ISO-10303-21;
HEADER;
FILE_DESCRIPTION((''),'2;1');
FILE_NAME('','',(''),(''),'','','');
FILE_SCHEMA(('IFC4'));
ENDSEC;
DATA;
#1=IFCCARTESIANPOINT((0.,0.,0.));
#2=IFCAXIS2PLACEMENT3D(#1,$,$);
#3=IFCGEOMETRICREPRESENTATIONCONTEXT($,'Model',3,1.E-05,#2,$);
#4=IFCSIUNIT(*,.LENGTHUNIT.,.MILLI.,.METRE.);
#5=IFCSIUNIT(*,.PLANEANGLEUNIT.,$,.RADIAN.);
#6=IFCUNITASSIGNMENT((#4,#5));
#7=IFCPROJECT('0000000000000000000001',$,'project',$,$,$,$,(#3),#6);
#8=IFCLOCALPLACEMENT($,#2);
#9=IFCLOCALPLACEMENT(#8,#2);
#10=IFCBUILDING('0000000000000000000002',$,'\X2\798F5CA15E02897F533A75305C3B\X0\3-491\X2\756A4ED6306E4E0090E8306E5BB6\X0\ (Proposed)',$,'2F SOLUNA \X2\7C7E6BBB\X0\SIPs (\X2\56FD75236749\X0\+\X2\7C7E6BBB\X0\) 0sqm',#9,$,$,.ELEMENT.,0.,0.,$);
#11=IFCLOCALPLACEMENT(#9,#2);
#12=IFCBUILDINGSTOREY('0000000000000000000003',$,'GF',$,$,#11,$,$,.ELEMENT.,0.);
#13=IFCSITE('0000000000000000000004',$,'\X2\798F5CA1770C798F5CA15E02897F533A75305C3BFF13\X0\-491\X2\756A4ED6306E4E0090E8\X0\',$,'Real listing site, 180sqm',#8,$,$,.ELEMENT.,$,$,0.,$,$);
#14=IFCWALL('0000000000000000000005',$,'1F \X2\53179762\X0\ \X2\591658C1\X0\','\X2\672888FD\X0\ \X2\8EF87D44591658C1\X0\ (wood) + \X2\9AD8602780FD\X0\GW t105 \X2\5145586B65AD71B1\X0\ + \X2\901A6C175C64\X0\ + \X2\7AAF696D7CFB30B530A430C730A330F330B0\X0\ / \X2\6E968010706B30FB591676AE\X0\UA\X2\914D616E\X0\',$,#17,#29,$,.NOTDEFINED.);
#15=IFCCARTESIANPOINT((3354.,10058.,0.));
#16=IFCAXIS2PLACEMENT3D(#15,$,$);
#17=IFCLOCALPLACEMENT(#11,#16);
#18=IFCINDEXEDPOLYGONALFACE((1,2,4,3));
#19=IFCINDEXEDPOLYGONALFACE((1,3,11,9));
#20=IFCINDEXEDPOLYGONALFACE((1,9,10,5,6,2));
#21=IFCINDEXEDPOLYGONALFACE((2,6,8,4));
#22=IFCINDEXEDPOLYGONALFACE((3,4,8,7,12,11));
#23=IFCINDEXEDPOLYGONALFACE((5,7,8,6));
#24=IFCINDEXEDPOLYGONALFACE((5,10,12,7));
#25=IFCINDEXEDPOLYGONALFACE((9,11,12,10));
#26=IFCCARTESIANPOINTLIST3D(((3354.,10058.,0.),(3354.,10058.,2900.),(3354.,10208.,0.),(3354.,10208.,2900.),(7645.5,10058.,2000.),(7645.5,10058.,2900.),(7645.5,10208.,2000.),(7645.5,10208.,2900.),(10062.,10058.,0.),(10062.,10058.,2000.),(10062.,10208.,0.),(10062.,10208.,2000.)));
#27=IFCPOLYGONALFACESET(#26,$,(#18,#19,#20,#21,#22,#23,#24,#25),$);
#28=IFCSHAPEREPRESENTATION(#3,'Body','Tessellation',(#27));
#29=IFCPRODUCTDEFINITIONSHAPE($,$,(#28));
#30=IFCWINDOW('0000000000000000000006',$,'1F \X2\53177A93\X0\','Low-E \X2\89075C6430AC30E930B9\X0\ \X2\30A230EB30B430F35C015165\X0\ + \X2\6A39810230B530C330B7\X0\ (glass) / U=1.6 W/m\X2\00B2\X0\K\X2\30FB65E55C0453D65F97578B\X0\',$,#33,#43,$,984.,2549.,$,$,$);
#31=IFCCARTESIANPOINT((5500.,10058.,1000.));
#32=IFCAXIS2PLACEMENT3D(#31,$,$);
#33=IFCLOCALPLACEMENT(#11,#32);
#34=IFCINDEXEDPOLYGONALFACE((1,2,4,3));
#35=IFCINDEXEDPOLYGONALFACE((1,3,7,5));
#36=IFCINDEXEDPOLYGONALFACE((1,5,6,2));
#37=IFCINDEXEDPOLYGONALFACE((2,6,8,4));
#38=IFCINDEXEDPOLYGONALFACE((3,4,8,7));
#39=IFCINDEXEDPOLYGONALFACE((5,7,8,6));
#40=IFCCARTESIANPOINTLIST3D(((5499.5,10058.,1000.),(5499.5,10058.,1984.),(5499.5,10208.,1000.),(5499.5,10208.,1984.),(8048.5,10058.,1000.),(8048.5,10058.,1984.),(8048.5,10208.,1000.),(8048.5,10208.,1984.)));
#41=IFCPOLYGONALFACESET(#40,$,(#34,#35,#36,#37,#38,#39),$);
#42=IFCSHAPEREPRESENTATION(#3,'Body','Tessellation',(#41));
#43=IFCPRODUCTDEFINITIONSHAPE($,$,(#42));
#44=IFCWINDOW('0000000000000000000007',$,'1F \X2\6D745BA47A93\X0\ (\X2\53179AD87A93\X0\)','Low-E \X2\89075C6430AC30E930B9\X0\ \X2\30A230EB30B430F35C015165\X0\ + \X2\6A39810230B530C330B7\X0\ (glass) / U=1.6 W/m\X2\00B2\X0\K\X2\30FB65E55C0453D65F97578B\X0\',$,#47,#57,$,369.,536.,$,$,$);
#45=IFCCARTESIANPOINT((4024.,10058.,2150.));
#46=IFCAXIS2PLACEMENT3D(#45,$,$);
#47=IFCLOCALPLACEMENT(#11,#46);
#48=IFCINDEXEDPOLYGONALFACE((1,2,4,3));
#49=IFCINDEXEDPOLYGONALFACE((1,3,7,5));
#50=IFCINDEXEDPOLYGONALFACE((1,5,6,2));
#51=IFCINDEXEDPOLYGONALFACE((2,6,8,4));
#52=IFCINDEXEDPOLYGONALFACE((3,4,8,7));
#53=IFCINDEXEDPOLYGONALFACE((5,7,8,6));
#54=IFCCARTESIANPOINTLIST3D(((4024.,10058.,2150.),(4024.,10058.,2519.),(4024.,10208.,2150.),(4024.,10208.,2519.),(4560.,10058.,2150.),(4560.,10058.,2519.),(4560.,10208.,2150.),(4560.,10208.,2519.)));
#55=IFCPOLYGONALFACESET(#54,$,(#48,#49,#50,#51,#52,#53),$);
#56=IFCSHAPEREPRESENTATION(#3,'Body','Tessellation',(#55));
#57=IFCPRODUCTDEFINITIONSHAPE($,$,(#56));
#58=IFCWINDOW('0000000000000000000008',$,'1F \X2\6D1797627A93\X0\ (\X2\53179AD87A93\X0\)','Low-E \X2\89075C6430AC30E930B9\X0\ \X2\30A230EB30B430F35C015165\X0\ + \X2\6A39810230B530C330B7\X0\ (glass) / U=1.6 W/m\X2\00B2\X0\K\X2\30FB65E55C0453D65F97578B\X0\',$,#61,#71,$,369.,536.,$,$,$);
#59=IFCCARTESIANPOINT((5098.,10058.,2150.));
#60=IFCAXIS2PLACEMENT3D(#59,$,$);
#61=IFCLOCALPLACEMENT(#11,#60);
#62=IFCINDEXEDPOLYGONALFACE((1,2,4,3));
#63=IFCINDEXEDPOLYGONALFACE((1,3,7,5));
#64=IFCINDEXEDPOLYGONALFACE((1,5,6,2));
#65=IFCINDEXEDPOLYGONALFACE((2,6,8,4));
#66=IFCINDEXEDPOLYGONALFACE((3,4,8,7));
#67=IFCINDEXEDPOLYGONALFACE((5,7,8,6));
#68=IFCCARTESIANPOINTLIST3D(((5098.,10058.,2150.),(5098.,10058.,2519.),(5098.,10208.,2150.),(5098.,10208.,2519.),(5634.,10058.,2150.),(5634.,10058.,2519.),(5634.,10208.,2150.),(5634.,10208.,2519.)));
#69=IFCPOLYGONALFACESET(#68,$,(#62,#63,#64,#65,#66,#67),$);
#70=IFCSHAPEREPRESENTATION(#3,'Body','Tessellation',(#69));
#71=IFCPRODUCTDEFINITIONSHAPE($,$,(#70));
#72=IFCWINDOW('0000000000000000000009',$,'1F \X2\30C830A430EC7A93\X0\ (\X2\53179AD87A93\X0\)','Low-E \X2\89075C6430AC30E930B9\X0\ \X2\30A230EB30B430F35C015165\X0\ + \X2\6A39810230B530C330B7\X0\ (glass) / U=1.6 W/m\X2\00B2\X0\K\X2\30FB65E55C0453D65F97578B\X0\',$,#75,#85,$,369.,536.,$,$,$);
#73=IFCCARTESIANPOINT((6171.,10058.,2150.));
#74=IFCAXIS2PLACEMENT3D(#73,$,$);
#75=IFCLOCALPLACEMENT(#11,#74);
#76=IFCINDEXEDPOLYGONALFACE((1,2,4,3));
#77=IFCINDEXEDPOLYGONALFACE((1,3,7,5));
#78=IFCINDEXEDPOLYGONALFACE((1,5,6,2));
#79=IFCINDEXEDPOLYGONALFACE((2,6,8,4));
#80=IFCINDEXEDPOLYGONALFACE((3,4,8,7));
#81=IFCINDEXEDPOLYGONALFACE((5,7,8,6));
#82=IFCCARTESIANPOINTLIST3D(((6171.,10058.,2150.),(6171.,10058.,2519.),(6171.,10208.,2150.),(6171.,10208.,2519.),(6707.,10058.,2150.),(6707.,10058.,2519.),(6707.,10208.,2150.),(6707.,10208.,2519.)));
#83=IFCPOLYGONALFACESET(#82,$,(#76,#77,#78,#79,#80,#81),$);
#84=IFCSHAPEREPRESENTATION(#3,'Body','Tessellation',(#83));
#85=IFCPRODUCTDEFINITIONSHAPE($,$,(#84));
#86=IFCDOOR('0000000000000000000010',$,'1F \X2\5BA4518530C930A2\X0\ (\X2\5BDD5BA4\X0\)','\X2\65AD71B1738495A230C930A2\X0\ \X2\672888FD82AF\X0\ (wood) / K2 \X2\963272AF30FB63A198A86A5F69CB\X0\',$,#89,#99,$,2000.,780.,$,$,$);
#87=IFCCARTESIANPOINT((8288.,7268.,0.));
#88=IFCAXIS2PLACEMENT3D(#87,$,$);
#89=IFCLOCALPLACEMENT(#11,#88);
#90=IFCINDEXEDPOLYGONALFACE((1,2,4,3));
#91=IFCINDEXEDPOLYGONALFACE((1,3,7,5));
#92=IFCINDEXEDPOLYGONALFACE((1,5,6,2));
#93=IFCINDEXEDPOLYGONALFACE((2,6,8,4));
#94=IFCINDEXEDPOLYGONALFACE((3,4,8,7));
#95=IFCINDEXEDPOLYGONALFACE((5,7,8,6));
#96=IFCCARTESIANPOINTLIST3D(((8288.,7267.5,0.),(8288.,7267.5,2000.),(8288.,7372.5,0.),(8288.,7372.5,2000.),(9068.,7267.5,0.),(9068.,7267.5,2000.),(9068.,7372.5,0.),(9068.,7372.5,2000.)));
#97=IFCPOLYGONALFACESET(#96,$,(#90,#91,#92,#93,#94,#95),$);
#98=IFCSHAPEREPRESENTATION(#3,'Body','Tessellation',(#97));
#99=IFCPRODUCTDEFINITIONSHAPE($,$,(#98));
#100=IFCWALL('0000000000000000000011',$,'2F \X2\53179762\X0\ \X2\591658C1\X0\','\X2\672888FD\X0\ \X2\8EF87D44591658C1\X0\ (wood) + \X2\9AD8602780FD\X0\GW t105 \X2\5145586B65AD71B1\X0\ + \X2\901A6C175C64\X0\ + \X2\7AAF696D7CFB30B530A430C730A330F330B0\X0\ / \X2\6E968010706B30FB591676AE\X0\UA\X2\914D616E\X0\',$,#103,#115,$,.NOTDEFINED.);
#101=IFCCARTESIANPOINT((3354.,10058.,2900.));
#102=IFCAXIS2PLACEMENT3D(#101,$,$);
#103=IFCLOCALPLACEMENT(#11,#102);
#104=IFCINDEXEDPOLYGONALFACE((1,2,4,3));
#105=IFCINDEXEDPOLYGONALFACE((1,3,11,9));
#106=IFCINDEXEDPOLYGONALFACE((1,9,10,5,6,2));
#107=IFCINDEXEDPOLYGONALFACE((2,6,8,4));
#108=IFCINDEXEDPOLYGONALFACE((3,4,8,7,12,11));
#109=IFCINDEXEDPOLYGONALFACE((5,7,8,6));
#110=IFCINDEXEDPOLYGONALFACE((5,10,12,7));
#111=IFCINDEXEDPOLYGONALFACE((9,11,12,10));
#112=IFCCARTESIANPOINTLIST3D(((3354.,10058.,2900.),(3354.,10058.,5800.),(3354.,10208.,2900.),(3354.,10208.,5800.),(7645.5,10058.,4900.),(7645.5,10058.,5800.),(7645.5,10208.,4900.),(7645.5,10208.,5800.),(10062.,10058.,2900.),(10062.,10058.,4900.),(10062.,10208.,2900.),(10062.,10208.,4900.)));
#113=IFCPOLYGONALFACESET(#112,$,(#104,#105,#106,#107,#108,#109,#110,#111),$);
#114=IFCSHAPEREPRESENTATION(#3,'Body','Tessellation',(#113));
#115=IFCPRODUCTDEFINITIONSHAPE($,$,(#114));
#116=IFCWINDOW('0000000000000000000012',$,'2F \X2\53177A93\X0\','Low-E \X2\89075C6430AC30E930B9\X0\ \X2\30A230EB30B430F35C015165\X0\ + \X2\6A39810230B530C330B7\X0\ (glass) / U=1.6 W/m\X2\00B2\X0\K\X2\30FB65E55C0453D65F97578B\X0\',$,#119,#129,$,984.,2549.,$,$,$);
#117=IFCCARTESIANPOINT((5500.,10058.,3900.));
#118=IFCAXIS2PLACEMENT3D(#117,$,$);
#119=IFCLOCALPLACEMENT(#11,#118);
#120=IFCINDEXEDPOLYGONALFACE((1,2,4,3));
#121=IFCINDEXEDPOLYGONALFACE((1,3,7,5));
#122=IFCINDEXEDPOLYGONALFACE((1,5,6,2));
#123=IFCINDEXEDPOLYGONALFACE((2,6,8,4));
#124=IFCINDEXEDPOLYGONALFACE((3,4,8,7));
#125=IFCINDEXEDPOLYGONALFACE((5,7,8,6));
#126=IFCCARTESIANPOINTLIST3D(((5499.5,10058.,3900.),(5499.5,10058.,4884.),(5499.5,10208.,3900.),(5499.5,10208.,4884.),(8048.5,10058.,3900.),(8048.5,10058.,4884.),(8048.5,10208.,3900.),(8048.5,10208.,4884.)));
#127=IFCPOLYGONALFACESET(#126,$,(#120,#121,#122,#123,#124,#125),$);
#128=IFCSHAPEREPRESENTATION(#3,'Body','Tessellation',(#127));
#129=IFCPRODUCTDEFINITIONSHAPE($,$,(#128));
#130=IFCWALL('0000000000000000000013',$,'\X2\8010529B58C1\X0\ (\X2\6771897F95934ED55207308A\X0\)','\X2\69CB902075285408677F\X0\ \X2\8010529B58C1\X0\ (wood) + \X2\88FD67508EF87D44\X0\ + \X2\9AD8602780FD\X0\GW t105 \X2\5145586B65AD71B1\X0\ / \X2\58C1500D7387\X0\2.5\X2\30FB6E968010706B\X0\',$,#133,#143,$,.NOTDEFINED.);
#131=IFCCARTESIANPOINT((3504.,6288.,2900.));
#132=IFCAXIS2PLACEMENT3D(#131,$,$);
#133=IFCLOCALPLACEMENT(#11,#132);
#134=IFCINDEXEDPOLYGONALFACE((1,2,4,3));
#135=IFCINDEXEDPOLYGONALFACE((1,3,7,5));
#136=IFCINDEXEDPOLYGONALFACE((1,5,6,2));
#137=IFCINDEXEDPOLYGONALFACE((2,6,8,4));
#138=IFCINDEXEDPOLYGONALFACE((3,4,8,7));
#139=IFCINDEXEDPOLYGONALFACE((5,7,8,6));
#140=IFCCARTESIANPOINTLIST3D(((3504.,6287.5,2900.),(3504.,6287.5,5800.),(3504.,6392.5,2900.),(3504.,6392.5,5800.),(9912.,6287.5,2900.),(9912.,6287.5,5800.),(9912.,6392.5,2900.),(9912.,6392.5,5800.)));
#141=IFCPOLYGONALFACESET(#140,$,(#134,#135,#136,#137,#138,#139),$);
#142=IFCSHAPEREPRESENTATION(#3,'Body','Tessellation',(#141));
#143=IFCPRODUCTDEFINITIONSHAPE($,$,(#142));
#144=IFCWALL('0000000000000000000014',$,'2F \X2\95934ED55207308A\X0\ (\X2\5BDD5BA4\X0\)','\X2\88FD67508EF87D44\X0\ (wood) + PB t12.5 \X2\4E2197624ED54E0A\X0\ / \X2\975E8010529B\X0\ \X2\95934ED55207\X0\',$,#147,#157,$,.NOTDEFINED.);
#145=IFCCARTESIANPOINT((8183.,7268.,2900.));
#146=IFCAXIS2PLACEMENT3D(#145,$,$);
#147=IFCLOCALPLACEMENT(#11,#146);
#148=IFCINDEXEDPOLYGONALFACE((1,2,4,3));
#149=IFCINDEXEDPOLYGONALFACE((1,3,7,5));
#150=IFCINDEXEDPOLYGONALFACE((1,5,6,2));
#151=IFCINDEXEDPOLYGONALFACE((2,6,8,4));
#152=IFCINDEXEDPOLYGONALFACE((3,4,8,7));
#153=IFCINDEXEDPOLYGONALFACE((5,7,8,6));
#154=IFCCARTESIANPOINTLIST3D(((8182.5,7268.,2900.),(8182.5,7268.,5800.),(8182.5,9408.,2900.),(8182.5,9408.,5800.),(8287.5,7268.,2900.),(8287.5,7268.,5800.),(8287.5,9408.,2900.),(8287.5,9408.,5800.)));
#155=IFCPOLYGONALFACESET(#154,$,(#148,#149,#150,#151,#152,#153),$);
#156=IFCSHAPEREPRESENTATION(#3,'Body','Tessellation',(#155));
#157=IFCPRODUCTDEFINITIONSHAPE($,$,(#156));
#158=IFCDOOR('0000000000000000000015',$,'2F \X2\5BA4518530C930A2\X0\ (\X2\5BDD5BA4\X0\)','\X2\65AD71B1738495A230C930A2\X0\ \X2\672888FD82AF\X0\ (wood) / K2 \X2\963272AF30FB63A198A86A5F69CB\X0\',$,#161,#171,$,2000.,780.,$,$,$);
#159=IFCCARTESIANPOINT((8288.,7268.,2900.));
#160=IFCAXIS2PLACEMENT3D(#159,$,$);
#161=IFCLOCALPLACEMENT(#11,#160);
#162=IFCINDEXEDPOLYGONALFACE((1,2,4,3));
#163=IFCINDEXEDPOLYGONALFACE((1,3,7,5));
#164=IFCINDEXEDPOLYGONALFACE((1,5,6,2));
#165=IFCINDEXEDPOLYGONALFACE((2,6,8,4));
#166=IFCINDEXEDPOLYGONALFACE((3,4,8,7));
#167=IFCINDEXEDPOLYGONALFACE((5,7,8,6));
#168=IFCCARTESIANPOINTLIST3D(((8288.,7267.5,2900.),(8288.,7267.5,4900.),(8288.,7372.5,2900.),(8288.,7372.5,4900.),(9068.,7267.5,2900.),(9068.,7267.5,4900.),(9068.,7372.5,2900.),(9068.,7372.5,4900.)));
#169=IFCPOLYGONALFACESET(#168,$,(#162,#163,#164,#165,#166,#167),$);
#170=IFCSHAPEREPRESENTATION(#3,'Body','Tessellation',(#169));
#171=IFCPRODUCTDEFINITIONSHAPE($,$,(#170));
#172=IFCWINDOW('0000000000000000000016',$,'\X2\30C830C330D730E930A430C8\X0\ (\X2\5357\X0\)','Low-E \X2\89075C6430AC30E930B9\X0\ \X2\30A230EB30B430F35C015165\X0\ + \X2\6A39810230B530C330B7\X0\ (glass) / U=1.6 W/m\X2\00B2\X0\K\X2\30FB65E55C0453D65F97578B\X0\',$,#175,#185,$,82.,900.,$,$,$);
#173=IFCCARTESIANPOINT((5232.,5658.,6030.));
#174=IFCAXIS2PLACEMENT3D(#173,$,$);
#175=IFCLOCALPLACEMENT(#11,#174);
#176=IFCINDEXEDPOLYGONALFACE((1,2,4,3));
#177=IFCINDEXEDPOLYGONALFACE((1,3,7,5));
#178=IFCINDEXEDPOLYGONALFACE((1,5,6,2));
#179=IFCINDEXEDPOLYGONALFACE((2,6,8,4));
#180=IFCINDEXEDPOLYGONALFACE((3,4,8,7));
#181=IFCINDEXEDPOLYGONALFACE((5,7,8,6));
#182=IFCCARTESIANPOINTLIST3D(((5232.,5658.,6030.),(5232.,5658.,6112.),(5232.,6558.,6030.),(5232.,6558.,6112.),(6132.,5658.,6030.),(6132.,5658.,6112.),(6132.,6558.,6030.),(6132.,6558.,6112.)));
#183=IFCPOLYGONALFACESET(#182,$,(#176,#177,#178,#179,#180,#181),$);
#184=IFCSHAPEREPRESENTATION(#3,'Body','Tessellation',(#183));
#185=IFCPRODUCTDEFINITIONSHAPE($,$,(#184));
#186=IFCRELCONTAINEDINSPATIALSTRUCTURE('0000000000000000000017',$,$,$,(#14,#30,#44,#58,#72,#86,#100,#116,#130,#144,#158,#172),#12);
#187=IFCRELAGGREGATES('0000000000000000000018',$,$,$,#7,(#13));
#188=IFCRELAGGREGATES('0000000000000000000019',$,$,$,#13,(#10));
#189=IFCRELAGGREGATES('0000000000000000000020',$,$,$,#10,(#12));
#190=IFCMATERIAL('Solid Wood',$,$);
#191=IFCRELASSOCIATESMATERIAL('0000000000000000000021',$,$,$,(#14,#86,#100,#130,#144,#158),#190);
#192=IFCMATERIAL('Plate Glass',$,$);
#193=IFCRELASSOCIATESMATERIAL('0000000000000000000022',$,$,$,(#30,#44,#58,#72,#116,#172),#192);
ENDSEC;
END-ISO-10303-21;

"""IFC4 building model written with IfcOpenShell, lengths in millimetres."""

from ifc_helpers import new_model, si_unit, frame, frame_2d, origin, place, context, project, spatial, rectangle, extrude, material, element, fill, save


model = new_model("IFC4")

# Units and contexts
model_context = context("Model", 3, precision=1e-05, world=origin())
ifc_project = project(units=[si_unit("LENGTHUNIT", "METRE", prefix="MILLI"), si_unit("PLANEANGLEUNIT", "RADIAN")], contexts=[model_context])

# Site, building, storey
site_placement = place(None, origin())
site = spatial("IfcSite", under=ifc_project, at=site_placement, Name="福岡県福岡市西区田尻３-491番他の一部", ObjectType="Real listing site, 180sqm", CompositionType="ELEMENT", RefElevation=0.0)
building_placement = place(site_placement, origin())
building = spatial("IfcBuilding", under=site, at=building_placement, Name="福岡市西区田尻3-491番他の一部の家 (Proposed)", ObjectType="2F SOLUNA 籾殻SIPs (国産杉+籾殻) 0sqm", CompositionType="ELEMENT", ElevationOfRefHeight=0.0, ElevationOfTerrain=0.0)
storey_placement = place(building_placement, origin())
storey = spatial("IfcBuildingStorey", under=building, at=storey_placement, Name="GF", CompositionType="ELEMENT", Elevation=0.0)

# Wall, openings, windows
ifc_material_1 = material(Name="Solid Wood")
wall_1_placement = place(storey_placement, frame((3354.0, 10058.0, 0.0)))
wall_1 = element("IfcWall", 1, at=wall_1_placement, inside=storey, material=ifc_material_1, Name="1F 北面 外壁", Description="木製 軸組外壁 (wood) + 高性能GW t105 充填断熱 + 通気層 + 窯業系サイディング / 準耐火・外皮UA配慮", PredefinedType="NOTDEFINED", context=model_context, shape_type="SweptSolid", body=[
    extrude(rectangle(XDim=6708.0, YDim=150.0, at=frame_2d((3354.0, 75.0))), frame((3354.0, 10058.0, 0.0)), (0.0, 0.0, 1.0), 2900.0),
])
opening_1_placement = place(storey_placement, frame((5500.0, 10058.0, 1000.0)))
opening_1 = element("IfcOpeningElement", 2, at=opening_1_placement, cuts=wall_1, PredefinedType="NOTDEFINED", context=model_context, shape_type="SweptSolid", body=[
    extrude(rectangle(XDim=2549.0, YDim=150.0, at=frame_2d((1274.0, 75.0))), frame((5500.0, 10058.0, 1000.0)), (0.0, 0.0, 1.0), 984.0),
])
opening_2_placement = place(storey_placement, frame((4024.0, 10058.0, 2150.0)))
opening_2 = element("IfcOpeningElement", 3, at=opening_2_placement, cuts=wall_1, PredefinedType="NOTDEFINED", context=model_context, shape_type="SweptSolid", body=[
    extrude(rectangle(XDim=536.0, YDim=150.0, at=frame_2d((268.0, 75.0))), frame((4024.0, 10058.0, 2150.0)), (0.0, 0.0, 1.0), 369.0),
])
opening_3_placement = place(storey_placement, frame((5098.0, 10058.0, 2150.0)))
opening_3 = element("IfcOpeningElement", 4, at=opening_3_placement, cuts=wall_1, PredefinedType="NOTDEFINED", context=model_context, shape_type="SweptSolid", body=[
    extrude(rectangle(XDim=536.0, YDim=150.0, at=frame_2d((268.0, 75.0))), frame((5098.0, 10058.0, 2150.0)), (0.0, 0.0, 1.0), 369.0),
])
opening_4_placement = place(storey_placement, frame((6171.0, 10058.0, 2150.0)))
opening_4 = element("IfcOpeningElement", 5, at=opening_4_placement, cuts=wall_1, PredefinedType="NOTDEFINED", context=model_context, shape_type="SweptSolid", body=[
    extrude(rectangle(XDim=536.0, YDim=150.0, at=frame_2d((268.0, 75.0))), frame((6171.0, 10058.0, 2150.0)), (0.0, 0.0, 1.0), 369.0),
])
ifc_material_2 = material(Name="Plate Glass")
window_1_placement = place(storey_placement, frame((5500.0, 10058.0, 1000.0)))
window_1 = element("IfcWindow", 6, at=window_1_placement, inside=storey, material=ifc_material_2, Name="1F 北窓", Description="Low-E 複層ガラス アルゴン封入 + 樹脂サッシ (glass) / U=1.6 W/m²K・日射取得型", OverallHeight=984.0, OverallWidth=2549.0, context=model_context, shape_type="SweptSolid", body=[
    extrude(rectangle(XDim=2549.0, YDim=150.0, at=frame_2d((1274.0, 75.0))), frame((5500.0, 10058.0, 1000.0)), (0.0, 0.0, 1.0), 984.0),
])
fill(opening_1, window_1)
window_2_placement = place(storey_placement, frame((4024.0, 10058.0, 2150.0)))
window_2 = element("IfcWindow", 7, at=window_2_placement, inside=storey, material=ifc_material_2, Name="1F 浴室窓 (北高窓)", Description="Low-E 複層ガラス アルゴン封入 + 樹脂サッシ (glass) / U=1.6 W/m²K・日射取得型", OverallHeight=369.0, OverallWidth=536.0, context=model_context, shape_type="SweptSolid", body=[
    extrude(rectangle(XDim=536.0, YDim=150.0, at=frame_2d((268.0, 75.0))), frame((4024.0, 10058.0, 2150.0)), (0.0, 0.0, 1.0), 369.0),
])
fill(opening_2, window_2)
window_3_placement = place(storey_placement, frame((5098.0, 10058.0, 2150.0)))
window_3 = element("IfcWindow", 8, at=window_3_placement, inside=storey, material=ifc_material_2, Name="1F 洗面窓 (北高窓)", Description="Low-E 複層ガラス アルゴン封入 + 樹脂サッシ (glass) / U=1.6 W/m²K・日射取得型", OverallHeight=369.0, OverallWidth=536.0, context=model_context, shape_type="SweptSolid", body=[
    extrude(rectangle(XDim=536.0, YDim=150.0, at=frame_2d((268.0, 75.0))), frame((5098.0, 10058.0, 2150.0)), (0.0, 0.0, 1.0), 369.0),
])
fill(opening_3, window_3)
window_4_placement = place(storey_placement, frame((6171.0, 10058.0, 2150.0)))
window_4 = element("IfcWindow", 9, at=window_4_placement, inside=storey, material=ifc_material_2, Name="1F トイレ窓 (北高窓)", Description="Low-E 複層ガラス アルゴン封入 + 樹脂サッシ (glass) / U=1.6 W/m²K・日射取得型", OverallHeight=369.0, OverallWidth=536.0, context=model_context, shape_type="SweptSolid", body=[
    extrude(rectangle(XDim=536.0, YDim=150.0, at=frame_2d((268.0, 75.0))), frame((6171.0, 10058.0, 2150.0)), (0.0, 0.0, 1.0), 369.0),
])
fill(opening_4, window_4)

# Door
door_1_placement = place(storey_placement, frame((8288.0, 7268.0, 0.0)))
element("IfcDoor", 10, at=door_1_placement, inside=storey, material=ifc_material_1, Name="1F 室内ドア (寝室)", Description="断熱玄関ドア 木製芯 (wood) / K2 防犯・採風機構", OverallHeight=2000.0, OverallWidth=780.0, context=model_context, shape_type="SweptSolid", body=[
    extrude(rectangle(XDim=780.0, YDim=105.0, at=frame_2d((390.0, 52.0))), frame((8288.0, 7268.0, 0.0)), (0.0, 0.0, 1.0), 2000.0),
])

# Wall, opening, window
wall_2_placement = place(storey_placement, frame((3354.0, 10058.0, 2900.0)))
wall_2 = element("IfcWall", 11, at=wall_2_placement, inside=storey, material=ifc_material_1, Name="2F 北面 外壁", Description="木製 軸組外壁 (wood) + 高性能GW t105 充填断熱 + 通気層 + 窯業系サイディング / 準耐火・外皮UA配慮", PredefinedType="NOTDEFINED", context=model_context, shape_type="SweptSolid", body=[
    extrude(rectangle(XDim=6708.0, YDim=150.0, at=frame_2d((3354.0, 75.0))), frame((3354.0, 10058.0, 2900.0)), (0.0, 0.0, 1.0), 2900.0),
])
opening_5_placement = place(storey_placement, frame((5500.0, 10058.0, 3900.0)))
opening_5 = element("IfcOpeningElement", 12, at=opening_5_placement, cuts=wall_2, PredefinedType="NOTDEFINED", context=model_context, shape_type="SweptSolid", body=[
    extrude(rectangle(XDim=2549.0, YDim=150.0, at=frame_2d((1274.0, 75.0))), frame((5500.0, 10058.0, 3900.0)), (0.0, 0.0, 1.0), 984.0),
])
window_5_placement = place(storey_placement, frame((5500.0, 10058.0, 3900.0)))
window_5 = element("IfcWindow", 13, at=window_5_placement, inside=storey, material=ifc_material_2, Name="2F 北窓", Description="Low-E 複層ガラス アルゴン封入 + 樹脂サッシ (glass) / U=1.6 W/m²K・日射取得型", OverallHeight=984.0, OverallWidth=2549.0, context=model_context, shape_type="SweptSolid", body=[
    extrude(rectangle(XDim=2549.0, YDim=150.0, at=frame_2d((1274.0, 75.0))), frame((5500.0, 10058.0, 3900.0)), (0.0, 0.0, 1.0), 984.0),
])
fill(opening_5, window_5)

# Walls
wall_3_placement = place(storey_placement, frame((3504.0, 6288.0, 2900.0)))
element("IfcWall", 14, at=wall_3_placement, inside=storey, material=ifc_material_1, Name="耐力壁 (東西間仕切り)", Description="構造用合板 耐力壁 (wood) + 製材軸組 + 高性能GW t105 充填断熱 / 壁倍率2.5・準耐火", PredefinedType="NOTDEFINED", context=model_context, shape_type="SweptSolid", body=[
    extrude(rectangle(XDim=6408.0, YDim=105.0, at=frame_2d((3204.0, 52.0))), frame((3504.0, 6288.0, 2900.0)), (0.0, 0.0, 1.0), 2900.0),
])
wall_4_placement = place(storey_placement, frame((8183.0, 7268.0, 2900.0)))
element("IfcWall", 15, at=wall_4_placement, inside=storey, material=ifc_material_1, Name="2F 間仕切り (寝室)", Description="製材軸組 (wood) + PB t12.5 両面仕上 / 非耐力 間仕切", PredefinedType="NOTDEFINED", context=model_context, shape_type="SweptSolid", body=[
    extrude(rectangle(XDim=105.0, YDim=2140.0, at=frame_2d((52.0, 1070.0))), frame((8183.0, 7268.0, 2900.0)), (0.0, 0.0, 1.0), 2900.0),
])

# Door
door_2_placement = place(storey_placement, frame((8288.0, 7268.0, 2900.0)))
element("IfcDoor", 16, at=door_2_placement, inside=storey, material=ifc_material_1, Name="2F 室内ドア (寝室)", Description="断熱玄関ドア 木製芯 (wood) / K2 防犯・採風機構", OverallHeight=2000.0, OverallWidth=780.0, context=model_context, shape_type="SweptSolid", body=[
    extrude(rectangle(XDim=780.0, YDim=105.0, at=frame_2d((390.0, 52.0))), frame((8288.0, 7268.0, 2900.0)), (0.0, 0.0, 1.0), 2000.0),
])

# Window
window_6_placement = place(storey_placement, frame((5232.0, 5658.0, 6030.0)))
element("IfcWindow", 17, at=window_6_placement, inside=storey, material=ifc_material_2, Name="トップライト (南)", Description="Low-E 複層ガラス アルゴン封入 + 樹脂サッシ (glass) / U=1.6 W/m²K・日射取得型", OverallHeight=82.0, OverallWidth=900.0, context=model_context, shape_type="SweptSolid", body=[
    extrude(rectangle(XDim=900.0, YDim=900.0, at=frame_2d((450.0, 450.0))), frame((5232.0, 5658.0, 6030.0)), (0.0, 0.0, 1.0), 82.0),
])

save(model, "model.ifc")
